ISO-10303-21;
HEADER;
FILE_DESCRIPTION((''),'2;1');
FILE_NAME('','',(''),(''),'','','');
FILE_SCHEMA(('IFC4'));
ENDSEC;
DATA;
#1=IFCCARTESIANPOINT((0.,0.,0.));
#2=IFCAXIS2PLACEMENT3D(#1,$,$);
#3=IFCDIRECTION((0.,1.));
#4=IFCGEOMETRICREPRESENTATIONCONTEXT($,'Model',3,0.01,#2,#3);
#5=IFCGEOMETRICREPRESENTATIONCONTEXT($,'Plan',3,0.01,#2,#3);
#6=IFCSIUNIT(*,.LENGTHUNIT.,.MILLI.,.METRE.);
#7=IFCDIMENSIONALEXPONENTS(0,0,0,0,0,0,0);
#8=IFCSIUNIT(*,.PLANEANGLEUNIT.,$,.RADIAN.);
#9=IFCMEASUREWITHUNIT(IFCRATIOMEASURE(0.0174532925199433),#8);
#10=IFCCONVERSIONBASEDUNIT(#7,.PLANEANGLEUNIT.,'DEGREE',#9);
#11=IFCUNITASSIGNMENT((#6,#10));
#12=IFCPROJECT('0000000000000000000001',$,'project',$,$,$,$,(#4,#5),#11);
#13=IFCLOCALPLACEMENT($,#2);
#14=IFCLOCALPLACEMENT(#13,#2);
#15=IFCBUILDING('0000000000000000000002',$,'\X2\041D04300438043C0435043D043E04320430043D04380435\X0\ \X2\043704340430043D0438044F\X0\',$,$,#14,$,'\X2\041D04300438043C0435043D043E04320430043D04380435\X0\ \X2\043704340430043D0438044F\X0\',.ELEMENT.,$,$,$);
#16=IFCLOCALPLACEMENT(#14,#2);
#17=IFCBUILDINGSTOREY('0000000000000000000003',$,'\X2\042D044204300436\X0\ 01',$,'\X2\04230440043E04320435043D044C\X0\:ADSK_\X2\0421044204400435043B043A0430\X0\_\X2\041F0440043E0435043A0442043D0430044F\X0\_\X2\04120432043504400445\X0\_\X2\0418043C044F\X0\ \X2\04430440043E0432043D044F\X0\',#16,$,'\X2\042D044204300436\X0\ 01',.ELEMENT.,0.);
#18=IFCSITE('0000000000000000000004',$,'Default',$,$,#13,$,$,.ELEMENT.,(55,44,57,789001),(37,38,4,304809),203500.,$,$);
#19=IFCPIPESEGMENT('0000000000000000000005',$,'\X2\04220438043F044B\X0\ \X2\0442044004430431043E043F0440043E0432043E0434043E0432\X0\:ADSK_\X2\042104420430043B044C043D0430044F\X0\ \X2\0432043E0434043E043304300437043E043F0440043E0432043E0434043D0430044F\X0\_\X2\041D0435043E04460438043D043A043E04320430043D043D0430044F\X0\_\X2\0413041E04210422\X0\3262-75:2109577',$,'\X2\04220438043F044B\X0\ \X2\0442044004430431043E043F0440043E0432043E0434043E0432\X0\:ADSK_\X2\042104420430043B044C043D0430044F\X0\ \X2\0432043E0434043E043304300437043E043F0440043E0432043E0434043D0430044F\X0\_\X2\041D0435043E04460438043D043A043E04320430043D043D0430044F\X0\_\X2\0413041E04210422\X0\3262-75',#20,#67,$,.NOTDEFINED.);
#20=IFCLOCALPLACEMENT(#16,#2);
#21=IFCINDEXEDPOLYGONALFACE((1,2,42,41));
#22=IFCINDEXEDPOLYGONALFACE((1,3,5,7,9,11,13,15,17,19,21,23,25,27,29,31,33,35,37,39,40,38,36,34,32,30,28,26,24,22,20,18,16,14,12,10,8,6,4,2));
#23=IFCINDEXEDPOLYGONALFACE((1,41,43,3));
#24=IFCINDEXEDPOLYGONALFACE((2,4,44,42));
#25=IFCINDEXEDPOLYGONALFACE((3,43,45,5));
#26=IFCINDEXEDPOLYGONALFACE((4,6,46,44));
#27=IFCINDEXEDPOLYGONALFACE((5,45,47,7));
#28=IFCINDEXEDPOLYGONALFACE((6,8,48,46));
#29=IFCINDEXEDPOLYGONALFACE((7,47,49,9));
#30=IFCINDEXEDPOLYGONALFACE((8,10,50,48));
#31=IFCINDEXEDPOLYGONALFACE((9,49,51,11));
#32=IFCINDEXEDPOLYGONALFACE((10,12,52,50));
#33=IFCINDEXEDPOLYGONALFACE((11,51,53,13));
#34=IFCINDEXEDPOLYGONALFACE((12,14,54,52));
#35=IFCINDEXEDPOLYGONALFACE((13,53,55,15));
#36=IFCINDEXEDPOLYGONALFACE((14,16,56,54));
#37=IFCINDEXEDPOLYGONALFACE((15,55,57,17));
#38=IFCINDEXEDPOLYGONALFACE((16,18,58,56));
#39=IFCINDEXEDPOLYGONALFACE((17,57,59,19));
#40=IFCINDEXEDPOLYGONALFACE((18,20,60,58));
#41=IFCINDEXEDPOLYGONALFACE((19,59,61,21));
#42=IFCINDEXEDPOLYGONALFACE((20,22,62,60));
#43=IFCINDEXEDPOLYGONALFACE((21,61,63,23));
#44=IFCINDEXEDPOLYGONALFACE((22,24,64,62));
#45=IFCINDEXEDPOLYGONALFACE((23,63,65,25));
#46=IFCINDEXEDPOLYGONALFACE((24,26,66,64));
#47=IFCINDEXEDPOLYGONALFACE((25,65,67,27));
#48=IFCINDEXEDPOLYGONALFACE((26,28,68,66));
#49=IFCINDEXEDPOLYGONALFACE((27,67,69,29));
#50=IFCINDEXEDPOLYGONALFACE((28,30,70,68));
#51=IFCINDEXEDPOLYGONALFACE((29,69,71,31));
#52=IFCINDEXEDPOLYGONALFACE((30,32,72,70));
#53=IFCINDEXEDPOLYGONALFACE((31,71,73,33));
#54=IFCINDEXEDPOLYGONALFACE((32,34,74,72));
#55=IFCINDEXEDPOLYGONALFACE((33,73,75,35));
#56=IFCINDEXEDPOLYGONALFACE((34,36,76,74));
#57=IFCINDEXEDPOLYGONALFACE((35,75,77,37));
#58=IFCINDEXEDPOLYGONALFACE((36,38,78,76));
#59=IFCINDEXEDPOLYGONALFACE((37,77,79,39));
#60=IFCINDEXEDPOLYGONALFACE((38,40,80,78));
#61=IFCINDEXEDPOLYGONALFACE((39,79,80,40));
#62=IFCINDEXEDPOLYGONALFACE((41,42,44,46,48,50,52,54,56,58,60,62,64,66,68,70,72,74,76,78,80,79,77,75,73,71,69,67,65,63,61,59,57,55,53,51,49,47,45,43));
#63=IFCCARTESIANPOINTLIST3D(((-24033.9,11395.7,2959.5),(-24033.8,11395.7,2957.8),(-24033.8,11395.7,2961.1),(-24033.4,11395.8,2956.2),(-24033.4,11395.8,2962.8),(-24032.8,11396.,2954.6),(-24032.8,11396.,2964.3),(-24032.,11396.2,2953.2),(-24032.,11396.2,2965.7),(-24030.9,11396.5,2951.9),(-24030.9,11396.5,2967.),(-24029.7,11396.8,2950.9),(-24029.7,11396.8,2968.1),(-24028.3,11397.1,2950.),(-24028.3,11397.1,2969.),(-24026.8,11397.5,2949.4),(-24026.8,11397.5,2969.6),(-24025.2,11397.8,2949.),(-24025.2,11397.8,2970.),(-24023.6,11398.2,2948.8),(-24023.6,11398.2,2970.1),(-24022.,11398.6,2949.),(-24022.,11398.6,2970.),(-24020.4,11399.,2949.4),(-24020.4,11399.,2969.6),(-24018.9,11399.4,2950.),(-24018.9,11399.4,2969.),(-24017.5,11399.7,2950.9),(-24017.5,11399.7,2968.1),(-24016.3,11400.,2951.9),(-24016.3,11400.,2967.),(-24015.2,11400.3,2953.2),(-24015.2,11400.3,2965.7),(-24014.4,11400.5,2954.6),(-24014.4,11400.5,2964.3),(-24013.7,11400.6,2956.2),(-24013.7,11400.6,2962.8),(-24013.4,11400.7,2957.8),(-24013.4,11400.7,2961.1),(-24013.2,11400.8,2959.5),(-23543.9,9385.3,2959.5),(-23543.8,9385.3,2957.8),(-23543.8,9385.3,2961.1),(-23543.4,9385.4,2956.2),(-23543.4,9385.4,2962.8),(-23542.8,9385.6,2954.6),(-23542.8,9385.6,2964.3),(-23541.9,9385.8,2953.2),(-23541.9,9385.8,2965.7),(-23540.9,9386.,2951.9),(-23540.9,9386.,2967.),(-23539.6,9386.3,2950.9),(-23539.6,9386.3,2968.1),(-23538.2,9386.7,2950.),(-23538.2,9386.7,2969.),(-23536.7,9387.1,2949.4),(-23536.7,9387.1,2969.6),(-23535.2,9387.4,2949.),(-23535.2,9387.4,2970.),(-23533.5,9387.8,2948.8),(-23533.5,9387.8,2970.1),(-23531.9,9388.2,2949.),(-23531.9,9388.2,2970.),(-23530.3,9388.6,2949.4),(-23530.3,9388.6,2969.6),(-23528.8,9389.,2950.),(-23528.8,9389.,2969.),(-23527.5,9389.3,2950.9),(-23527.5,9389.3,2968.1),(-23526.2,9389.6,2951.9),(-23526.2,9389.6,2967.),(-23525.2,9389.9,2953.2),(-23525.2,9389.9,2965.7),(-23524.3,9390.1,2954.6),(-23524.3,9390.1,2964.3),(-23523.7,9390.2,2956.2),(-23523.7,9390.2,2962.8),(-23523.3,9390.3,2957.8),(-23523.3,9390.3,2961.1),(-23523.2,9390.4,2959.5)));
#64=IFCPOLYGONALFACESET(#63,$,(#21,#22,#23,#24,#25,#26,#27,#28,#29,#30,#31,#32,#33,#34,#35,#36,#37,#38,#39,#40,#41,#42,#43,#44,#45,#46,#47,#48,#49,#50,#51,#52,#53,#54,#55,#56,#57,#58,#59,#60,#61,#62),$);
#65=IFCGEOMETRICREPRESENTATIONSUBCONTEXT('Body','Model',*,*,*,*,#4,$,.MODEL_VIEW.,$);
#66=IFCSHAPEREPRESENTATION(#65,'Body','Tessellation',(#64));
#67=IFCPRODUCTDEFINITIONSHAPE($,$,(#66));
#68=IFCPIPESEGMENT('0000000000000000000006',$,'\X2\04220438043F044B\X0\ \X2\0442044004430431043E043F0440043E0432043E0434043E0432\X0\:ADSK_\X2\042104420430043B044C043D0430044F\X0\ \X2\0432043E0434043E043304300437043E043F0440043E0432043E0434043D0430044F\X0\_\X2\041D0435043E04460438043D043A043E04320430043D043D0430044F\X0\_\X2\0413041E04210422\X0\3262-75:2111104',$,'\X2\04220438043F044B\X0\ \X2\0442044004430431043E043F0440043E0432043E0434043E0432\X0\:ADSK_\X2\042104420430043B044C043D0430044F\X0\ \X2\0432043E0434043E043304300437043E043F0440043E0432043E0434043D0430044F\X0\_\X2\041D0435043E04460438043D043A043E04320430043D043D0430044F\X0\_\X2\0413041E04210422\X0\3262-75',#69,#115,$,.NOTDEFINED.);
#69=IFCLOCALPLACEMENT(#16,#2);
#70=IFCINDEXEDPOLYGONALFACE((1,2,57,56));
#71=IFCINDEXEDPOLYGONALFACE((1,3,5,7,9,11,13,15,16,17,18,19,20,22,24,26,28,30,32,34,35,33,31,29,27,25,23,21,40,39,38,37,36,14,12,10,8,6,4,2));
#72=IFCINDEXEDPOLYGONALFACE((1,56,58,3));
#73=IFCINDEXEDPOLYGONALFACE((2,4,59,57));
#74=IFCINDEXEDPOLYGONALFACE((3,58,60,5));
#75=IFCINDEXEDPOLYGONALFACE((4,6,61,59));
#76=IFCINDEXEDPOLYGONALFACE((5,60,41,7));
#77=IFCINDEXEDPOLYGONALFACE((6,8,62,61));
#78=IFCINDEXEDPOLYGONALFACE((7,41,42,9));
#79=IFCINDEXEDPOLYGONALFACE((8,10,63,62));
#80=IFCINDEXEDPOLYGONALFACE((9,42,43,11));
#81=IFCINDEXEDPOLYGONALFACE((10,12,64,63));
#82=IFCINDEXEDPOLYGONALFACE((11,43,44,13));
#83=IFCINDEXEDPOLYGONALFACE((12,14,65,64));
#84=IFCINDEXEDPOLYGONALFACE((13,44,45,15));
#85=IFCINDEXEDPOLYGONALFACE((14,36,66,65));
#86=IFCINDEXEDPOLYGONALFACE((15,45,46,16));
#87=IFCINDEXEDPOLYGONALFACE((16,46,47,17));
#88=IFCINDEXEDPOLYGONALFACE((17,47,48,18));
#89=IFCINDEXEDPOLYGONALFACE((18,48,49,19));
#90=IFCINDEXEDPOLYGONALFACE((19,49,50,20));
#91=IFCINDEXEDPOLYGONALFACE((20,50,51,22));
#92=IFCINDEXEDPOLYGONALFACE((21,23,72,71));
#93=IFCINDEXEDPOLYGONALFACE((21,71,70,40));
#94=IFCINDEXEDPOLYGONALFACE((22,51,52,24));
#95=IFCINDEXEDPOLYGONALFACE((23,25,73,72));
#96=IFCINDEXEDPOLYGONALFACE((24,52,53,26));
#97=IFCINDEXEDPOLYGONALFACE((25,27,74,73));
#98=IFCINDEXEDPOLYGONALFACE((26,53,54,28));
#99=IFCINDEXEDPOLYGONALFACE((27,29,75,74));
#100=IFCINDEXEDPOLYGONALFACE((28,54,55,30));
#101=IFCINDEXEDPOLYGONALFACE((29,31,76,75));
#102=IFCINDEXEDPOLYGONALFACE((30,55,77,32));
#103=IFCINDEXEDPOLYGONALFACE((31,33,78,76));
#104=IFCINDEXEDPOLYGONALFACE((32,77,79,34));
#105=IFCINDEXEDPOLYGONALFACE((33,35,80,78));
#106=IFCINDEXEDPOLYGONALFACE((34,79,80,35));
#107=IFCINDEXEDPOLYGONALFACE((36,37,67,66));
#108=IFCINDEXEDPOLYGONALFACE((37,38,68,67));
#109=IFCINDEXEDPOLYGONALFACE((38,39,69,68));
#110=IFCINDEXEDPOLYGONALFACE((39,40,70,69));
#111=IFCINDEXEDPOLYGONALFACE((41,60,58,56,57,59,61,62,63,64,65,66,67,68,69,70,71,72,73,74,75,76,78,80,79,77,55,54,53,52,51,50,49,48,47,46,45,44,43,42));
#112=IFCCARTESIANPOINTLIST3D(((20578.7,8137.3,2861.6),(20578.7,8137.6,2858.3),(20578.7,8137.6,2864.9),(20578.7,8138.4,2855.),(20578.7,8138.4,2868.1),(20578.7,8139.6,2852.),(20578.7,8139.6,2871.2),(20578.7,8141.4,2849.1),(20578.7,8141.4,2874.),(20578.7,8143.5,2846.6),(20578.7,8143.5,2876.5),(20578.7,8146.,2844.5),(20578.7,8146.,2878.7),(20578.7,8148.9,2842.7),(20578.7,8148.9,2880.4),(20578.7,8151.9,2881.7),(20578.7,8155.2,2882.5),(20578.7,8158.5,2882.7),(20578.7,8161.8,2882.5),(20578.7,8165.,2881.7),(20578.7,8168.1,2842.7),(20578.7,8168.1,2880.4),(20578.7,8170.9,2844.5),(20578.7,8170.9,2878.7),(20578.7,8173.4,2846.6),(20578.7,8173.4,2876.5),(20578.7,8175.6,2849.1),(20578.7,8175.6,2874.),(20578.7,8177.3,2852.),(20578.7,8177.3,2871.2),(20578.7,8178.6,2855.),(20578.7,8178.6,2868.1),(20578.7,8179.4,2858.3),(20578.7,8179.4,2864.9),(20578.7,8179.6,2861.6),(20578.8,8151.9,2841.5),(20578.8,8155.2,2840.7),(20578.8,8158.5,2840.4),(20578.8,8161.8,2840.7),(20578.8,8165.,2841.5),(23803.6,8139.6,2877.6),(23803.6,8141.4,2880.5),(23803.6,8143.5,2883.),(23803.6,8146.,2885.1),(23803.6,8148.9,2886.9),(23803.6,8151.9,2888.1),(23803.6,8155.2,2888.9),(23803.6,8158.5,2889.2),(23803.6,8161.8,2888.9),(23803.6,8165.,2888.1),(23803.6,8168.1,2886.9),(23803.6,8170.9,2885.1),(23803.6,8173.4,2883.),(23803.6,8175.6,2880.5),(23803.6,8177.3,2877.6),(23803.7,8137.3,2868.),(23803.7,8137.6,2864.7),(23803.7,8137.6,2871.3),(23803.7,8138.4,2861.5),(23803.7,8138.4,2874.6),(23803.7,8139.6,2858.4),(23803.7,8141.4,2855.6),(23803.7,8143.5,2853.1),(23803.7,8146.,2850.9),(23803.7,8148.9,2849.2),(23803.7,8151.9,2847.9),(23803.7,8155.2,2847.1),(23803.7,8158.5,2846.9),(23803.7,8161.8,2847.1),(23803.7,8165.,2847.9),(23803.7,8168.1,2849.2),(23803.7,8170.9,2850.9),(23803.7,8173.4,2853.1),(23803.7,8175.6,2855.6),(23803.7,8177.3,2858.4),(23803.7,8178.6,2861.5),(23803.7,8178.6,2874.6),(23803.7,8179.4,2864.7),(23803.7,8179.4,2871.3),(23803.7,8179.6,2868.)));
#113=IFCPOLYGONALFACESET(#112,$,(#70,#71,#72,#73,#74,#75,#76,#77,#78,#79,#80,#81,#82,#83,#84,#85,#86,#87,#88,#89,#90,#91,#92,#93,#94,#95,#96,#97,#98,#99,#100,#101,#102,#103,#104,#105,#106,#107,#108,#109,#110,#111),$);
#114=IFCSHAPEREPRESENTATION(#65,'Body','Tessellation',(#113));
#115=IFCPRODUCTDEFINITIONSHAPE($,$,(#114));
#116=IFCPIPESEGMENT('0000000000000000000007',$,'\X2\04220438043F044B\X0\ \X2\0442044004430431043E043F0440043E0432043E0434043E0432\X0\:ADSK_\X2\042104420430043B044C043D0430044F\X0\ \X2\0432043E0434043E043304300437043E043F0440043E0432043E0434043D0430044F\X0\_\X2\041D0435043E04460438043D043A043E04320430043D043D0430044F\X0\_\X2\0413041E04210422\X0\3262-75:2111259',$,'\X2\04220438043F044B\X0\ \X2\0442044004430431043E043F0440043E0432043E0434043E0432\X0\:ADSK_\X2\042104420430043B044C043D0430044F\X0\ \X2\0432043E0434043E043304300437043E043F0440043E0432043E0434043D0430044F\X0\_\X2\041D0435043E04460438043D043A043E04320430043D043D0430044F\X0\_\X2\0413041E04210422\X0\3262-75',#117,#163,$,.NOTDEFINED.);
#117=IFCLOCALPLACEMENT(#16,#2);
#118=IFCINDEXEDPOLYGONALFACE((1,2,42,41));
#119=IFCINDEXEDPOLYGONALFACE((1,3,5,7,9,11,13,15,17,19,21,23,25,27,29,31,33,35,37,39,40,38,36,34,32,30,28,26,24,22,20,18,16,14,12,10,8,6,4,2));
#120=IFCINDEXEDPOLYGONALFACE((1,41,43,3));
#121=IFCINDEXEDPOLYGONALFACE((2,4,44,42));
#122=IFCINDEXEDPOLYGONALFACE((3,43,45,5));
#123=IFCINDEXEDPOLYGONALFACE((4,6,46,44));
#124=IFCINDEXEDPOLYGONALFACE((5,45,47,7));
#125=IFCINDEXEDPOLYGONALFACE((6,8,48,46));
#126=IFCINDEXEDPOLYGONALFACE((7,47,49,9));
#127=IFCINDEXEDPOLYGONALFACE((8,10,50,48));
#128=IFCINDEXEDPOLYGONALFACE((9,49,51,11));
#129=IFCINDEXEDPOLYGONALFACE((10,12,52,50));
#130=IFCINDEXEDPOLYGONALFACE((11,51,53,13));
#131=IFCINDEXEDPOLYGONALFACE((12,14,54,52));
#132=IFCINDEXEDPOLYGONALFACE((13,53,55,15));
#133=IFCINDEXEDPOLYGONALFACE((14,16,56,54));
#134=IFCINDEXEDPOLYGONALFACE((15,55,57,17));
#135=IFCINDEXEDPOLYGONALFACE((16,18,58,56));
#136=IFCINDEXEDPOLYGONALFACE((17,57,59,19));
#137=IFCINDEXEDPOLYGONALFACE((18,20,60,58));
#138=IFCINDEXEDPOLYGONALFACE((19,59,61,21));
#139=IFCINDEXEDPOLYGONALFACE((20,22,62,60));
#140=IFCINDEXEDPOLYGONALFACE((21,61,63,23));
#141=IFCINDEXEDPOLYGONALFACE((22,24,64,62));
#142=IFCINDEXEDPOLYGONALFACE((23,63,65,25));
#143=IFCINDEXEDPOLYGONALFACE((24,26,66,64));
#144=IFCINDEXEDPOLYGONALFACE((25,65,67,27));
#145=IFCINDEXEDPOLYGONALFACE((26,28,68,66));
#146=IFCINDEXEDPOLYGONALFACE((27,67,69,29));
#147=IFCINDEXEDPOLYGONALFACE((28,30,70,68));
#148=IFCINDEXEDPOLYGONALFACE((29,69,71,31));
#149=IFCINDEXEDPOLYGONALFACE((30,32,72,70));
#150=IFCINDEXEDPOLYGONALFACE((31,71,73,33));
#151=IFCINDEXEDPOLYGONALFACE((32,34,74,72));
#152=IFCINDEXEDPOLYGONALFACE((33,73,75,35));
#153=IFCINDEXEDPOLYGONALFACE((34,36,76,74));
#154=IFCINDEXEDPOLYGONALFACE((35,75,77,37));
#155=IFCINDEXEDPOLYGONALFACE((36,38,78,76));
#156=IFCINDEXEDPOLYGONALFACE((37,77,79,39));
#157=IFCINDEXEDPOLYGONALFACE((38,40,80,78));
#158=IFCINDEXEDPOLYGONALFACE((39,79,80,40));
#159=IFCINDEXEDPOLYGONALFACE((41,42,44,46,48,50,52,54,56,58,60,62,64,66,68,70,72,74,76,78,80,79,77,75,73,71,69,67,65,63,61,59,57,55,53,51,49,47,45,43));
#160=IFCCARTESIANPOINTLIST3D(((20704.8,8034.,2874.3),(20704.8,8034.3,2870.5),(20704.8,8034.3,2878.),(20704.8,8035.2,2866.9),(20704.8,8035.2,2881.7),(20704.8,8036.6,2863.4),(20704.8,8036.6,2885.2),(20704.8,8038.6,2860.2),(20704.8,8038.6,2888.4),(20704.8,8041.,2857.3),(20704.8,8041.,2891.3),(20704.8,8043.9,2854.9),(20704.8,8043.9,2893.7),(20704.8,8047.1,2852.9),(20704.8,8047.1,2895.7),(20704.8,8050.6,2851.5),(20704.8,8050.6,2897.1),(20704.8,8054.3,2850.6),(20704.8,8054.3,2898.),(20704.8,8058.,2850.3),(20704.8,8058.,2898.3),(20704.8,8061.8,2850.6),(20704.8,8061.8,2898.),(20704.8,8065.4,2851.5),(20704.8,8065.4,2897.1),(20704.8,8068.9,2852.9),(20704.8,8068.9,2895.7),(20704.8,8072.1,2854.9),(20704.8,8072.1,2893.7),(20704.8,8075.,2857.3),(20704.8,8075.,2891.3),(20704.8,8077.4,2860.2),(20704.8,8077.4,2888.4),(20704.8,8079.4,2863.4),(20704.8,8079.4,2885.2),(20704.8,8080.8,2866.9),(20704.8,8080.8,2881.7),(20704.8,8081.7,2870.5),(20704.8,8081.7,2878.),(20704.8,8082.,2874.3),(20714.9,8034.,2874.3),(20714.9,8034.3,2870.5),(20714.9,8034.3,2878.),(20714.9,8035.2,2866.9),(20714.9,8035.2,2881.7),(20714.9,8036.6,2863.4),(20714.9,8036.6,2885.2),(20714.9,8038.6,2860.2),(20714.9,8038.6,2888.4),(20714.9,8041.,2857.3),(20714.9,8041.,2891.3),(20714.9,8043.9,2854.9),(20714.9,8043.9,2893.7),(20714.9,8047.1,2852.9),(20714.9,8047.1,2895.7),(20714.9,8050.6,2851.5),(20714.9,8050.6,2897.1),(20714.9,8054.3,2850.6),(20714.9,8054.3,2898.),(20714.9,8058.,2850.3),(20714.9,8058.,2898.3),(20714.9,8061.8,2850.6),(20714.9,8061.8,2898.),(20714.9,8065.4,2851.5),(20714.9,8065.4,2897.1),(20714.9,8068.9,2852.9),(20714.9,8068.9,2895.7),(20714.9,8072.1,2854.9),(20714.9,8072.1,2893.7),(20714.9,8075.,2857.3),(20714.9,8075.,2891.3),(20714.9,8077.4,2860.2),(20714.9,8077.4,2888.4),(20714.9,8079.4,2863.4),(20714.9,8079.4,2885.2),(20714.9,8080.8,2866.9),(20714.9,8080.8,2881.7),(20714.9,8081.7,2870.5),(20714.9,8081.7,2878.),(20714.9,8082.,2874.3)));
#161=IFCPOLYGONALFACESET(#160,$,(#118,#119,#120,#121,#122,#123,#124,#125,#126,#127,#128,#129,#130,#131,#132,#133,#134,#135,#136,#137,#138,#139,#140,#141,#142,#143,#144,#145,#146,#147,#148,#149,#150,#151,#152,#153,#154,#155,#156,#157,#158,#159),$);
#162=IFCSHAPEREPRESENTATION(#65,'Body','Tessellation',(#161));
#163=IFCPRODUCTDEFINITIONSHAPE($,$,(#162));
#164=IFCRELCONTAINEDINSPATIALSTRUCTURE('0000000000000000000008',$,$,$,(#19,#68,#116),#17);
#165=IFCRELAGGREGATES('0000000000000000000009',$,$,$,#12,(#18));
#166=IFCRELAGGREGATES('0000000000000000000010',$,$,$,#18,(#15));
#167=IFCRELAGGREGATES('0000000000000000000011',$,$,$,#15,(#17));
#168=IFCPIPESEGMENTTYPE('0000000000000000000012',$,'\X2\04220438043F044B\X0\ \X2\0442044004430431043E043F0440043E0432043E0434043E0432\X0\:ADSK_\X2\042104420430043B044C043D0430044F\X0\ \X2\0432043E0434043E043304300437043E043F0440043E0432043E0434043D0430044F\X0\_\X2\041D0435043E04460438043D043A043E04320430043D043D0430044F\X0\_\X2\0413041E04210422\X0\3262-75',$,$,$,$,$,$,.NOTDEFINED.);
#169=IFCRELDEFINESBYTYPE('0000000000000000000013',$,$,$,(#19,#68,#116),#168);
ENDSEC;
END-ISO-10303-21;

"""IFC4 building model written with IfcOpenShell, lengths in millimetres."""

from ifc_helpers import new_model, entity, si_unit, converted_unit, direction, frame, origin, place, context, subcontext, project, spatial, indexed_curve, outline, extrude, type_object, element, save


model = new_model("IFC4")

# Units and contexts
model_context = context("Model", 3, precision=0.01, world=origin(), true_north=direction((0.0, 1.0)))
plan_context = context("Plan", 3, precision=0.01, world=origin(), true_north=direction((0.0, 1.0)))
body_context = subcontext(model_context, "Body", "Model", "MODEL_VIEW")
ifc_project = project(units=[si_unit("LENGTHUNIT", "METRE", prefix="MILLI"), converted_unit("PLANEANGLEUNIT", "DEGREE", entity("IfcRatioMeasure", 0.0174532925199433), si_unit("PLANEANGLEUNIT", "RADIAN"), dimensions=[0, 0, 0, 0, 0, 0, 0])], contexts=[model_context, plan_context])

# Site, building, storey
site_placement = place(None, origin())
site = spatial("IfcSite", under=ifc_project, at=site_placement, Name="Default", CompositionType="ELEMENT", RefLatitude=(55, 44, 57, 789001), RefLongitude=(37, 38, 4, 304809), RefElevation=203500.0)
building_placement = place(site_placement, origin())
building = spatial("IfcBuilding", under=site, at=building_placement, Name="Наименование здания", LongName="Наименование здания", CompositionType="ELEMENT")
storey_placement = place(building_placement, origin())
storey = spatial("IfcBuildingStorey", under=building, at=storey_placement, Name="Этаж 01", ObjectType="Уровень:ADSK_Стрелка_Проектная_Вверх_Имя уровня", LongName="Этаж 01", CompositionType="ELEMENT", Elevation=0.0)

# Pipe segments
pipe_segment_type = type_object("IfcPipeSegmentType", Name="Типы трубопроводов:ADSK_Стальная водогазопроводная_Неоцинкованная_ГОСТ3262-75", PredefinedType="NOTDEFINED")
placement = place(storey_placement, origin())
element("IfcPipeSegment", 1, at=placement, inside=storey, type_object=pipe_segment_type, Name="Типы трубопроводов:ADSK_Стальная водогазопроводная_Неоцинкованная_ГОСТ3262-75:2109577", ObjectType="Типы трубопроводов:ADSK_Стальная водогазопроводная_Неоцинкованная_ГОСТ3262-75", PredefinedType="NOTDEFINED", context=body_context, shape_type="SweptSolid", body=[
    extrude(outline(indexed_curve([(10.7, 0.0), (10.5, 1.7), (10.1, 3.3), (9.5, 4.8), (8.6, 6.3), (7.5, 7.5), (6.3, 8.6), (4.8, 9.5), (3.3, 10.1), (1.7, 10.5), (0.0, 10.6), (-1.7, 10.5), (-3.3, 10.1), (-4.8, 9.5), (-6.3, 8.6), (-7.5, 7.5), (-8.6, 6.3), (-9.5, 4.8), (-10.1, 3.3), (-10.5, 1.7), (-10.7, 0.0), (-10.5, -1.7), (-10.1, -3.3), (-9.5, -4.8), (-8.6, -6.3), (-7.5, -7.5), (-6.3, -8.6), (-4.8, -9.5), (-3.3, -10.1), (-1.7, -10.5), (0.0, -10.6), (1.7, -10.5), (3.3, -10.1), (4.8, -9.5), (6.3, -8.6), (7.5, -7.5), (8.6, -6.3), (9.5, -4.8), (10.1, -3.3), (10.5, -1.7), (10.7, 0.0)], self_intersect=False)), frame((-23533.5, 9387.8, 2959.5), z_axis=(-0.236821, 0.971553, 0.0), x_axis=(0.971553, 0.236821, 0.0)), (0.0, 0.0, 1.0), 2069.3),
])
element("IfcPipeSegment", 2, at=placement, inside=storey, type_object=pipe_segment_type, Name="Типы трубопроводов:ADSK_Стальная водогазопроводная_Неоцинкованная_ГОСТ3262-75:2111104", ObjectType="Типы трубопроводов:ADSK_Стальная водогазопроводная_Неоцинкованная_ГОСТ3262-75", PredefinedType="NOTDEFINED", context=body_context, shape_type="SweptSolid", body=[
    extrude(outline(indexed_curve([(21.1, 0.0), (20.9, 3.3), (20.1, 6.5), (18.8, 9.6), (17.1, 12.4), (15.0, 15.0), (12.4, 17.1), (9.6, 18.8), (6.5, 20.1), (3.3, 20.9), (0.0, 21.2), (-3.3, 20.9), (-6.5, 20.1), (-9.6, 18.8), (-12.4, 17.1), (-15.0, 15.0), (-17.1, 12.4), (-18.8, 9.6), (-20.1, 6.5), (-20.9, 3.3), (-21.1, 0.0), (-20.9, -3.3), (-20.1, -6.5), (-18.8, -9.6), (-17.1, -12.4), (-15.0, -15.0), (-12.4, -17.1), (-9.6, -18.8), (-6.5, -20.1), (-3.3, -20.9), (0.0, -21.2), (3.3, -20.9), (6.5, -20.1), (9.6, -18.8), (12.4, -17.1), (15.0, -15.0), (17.1, -12.4), (18.8, -9.6), (20.1, -6.5), (20.9, -3.3), (21.1, 0.0)], self_intersect=False)), frame((20578.7, 8158.5, 2861.6), z_axis=(0.999998, 0.0, 0.002), x_axis=(0.0, -1.0, 0.0)), (0.0, 0.0, 1.0), 3225.0),
])
element("IfcPipeSegment", 3, at=placement, inside=storey, type_object=pipe_segment_type, Name="Типы трубопроводов:ADSK_Стальная водогазопроводная_Неоцинкованная_ГОСТ3262-75:2111259", ObjectType="Типы трубопроводов:ADSK_Стальная водогазопроводная_Неоцинкованная_ГОСТ3262-75", PredefinedType="NOTDEFINED", context=body_context, shape_type="SweptSolid", body=[
    extrude(outline(indexed_curve([(24.0, 0.0), (23.7, 3.8), (22.8, 7.4), (21.4, 10.9), (19.4, 14.1), (17.0, 17.0), (14.1, 19.4), (10.9, 21.4), (7.4, 22.8), (3.8, 23.7), (0.0, 24.0), (-3.8, 23.7), (-7.4, 22.8), (-10.9, 21.4), (-14.1, 19.4), (-17.0, 17.0), (-19.4, 14.1), (-21.4, 10.9), (-22.8, 7.4), (-23.7, 3.8), (-24.0, 0.0), (-23.7, -3.8), (-22.8, -7.4), (-21.4, -10.9), (-19.4, -14.1), (-17.0, -17.0), (-14.1, -19.4), (-10.9, -21.4), (-7.4, -22.8), (-3.8, -23.7), (0.0, -24.0), (3.8, -23.7), (7.4, -22.8), (10.9, -21.4), (14.1, -19.4), (17.0, -17.0), (19.4, -14.1), (21.4, -10.9), (22.8, -7.4), (23.7, -3.8), (24.0, 0.0)], self_intersect=False)), frame((20704.8, 8058.0, 2874.3), z_axis=(1.0, 0.0, 0.0), x_axis=(0.0, 1.0, 0.0)), (0.0, 0.0, 1.0), 10.1),
])

save(model, "model.ifc")
